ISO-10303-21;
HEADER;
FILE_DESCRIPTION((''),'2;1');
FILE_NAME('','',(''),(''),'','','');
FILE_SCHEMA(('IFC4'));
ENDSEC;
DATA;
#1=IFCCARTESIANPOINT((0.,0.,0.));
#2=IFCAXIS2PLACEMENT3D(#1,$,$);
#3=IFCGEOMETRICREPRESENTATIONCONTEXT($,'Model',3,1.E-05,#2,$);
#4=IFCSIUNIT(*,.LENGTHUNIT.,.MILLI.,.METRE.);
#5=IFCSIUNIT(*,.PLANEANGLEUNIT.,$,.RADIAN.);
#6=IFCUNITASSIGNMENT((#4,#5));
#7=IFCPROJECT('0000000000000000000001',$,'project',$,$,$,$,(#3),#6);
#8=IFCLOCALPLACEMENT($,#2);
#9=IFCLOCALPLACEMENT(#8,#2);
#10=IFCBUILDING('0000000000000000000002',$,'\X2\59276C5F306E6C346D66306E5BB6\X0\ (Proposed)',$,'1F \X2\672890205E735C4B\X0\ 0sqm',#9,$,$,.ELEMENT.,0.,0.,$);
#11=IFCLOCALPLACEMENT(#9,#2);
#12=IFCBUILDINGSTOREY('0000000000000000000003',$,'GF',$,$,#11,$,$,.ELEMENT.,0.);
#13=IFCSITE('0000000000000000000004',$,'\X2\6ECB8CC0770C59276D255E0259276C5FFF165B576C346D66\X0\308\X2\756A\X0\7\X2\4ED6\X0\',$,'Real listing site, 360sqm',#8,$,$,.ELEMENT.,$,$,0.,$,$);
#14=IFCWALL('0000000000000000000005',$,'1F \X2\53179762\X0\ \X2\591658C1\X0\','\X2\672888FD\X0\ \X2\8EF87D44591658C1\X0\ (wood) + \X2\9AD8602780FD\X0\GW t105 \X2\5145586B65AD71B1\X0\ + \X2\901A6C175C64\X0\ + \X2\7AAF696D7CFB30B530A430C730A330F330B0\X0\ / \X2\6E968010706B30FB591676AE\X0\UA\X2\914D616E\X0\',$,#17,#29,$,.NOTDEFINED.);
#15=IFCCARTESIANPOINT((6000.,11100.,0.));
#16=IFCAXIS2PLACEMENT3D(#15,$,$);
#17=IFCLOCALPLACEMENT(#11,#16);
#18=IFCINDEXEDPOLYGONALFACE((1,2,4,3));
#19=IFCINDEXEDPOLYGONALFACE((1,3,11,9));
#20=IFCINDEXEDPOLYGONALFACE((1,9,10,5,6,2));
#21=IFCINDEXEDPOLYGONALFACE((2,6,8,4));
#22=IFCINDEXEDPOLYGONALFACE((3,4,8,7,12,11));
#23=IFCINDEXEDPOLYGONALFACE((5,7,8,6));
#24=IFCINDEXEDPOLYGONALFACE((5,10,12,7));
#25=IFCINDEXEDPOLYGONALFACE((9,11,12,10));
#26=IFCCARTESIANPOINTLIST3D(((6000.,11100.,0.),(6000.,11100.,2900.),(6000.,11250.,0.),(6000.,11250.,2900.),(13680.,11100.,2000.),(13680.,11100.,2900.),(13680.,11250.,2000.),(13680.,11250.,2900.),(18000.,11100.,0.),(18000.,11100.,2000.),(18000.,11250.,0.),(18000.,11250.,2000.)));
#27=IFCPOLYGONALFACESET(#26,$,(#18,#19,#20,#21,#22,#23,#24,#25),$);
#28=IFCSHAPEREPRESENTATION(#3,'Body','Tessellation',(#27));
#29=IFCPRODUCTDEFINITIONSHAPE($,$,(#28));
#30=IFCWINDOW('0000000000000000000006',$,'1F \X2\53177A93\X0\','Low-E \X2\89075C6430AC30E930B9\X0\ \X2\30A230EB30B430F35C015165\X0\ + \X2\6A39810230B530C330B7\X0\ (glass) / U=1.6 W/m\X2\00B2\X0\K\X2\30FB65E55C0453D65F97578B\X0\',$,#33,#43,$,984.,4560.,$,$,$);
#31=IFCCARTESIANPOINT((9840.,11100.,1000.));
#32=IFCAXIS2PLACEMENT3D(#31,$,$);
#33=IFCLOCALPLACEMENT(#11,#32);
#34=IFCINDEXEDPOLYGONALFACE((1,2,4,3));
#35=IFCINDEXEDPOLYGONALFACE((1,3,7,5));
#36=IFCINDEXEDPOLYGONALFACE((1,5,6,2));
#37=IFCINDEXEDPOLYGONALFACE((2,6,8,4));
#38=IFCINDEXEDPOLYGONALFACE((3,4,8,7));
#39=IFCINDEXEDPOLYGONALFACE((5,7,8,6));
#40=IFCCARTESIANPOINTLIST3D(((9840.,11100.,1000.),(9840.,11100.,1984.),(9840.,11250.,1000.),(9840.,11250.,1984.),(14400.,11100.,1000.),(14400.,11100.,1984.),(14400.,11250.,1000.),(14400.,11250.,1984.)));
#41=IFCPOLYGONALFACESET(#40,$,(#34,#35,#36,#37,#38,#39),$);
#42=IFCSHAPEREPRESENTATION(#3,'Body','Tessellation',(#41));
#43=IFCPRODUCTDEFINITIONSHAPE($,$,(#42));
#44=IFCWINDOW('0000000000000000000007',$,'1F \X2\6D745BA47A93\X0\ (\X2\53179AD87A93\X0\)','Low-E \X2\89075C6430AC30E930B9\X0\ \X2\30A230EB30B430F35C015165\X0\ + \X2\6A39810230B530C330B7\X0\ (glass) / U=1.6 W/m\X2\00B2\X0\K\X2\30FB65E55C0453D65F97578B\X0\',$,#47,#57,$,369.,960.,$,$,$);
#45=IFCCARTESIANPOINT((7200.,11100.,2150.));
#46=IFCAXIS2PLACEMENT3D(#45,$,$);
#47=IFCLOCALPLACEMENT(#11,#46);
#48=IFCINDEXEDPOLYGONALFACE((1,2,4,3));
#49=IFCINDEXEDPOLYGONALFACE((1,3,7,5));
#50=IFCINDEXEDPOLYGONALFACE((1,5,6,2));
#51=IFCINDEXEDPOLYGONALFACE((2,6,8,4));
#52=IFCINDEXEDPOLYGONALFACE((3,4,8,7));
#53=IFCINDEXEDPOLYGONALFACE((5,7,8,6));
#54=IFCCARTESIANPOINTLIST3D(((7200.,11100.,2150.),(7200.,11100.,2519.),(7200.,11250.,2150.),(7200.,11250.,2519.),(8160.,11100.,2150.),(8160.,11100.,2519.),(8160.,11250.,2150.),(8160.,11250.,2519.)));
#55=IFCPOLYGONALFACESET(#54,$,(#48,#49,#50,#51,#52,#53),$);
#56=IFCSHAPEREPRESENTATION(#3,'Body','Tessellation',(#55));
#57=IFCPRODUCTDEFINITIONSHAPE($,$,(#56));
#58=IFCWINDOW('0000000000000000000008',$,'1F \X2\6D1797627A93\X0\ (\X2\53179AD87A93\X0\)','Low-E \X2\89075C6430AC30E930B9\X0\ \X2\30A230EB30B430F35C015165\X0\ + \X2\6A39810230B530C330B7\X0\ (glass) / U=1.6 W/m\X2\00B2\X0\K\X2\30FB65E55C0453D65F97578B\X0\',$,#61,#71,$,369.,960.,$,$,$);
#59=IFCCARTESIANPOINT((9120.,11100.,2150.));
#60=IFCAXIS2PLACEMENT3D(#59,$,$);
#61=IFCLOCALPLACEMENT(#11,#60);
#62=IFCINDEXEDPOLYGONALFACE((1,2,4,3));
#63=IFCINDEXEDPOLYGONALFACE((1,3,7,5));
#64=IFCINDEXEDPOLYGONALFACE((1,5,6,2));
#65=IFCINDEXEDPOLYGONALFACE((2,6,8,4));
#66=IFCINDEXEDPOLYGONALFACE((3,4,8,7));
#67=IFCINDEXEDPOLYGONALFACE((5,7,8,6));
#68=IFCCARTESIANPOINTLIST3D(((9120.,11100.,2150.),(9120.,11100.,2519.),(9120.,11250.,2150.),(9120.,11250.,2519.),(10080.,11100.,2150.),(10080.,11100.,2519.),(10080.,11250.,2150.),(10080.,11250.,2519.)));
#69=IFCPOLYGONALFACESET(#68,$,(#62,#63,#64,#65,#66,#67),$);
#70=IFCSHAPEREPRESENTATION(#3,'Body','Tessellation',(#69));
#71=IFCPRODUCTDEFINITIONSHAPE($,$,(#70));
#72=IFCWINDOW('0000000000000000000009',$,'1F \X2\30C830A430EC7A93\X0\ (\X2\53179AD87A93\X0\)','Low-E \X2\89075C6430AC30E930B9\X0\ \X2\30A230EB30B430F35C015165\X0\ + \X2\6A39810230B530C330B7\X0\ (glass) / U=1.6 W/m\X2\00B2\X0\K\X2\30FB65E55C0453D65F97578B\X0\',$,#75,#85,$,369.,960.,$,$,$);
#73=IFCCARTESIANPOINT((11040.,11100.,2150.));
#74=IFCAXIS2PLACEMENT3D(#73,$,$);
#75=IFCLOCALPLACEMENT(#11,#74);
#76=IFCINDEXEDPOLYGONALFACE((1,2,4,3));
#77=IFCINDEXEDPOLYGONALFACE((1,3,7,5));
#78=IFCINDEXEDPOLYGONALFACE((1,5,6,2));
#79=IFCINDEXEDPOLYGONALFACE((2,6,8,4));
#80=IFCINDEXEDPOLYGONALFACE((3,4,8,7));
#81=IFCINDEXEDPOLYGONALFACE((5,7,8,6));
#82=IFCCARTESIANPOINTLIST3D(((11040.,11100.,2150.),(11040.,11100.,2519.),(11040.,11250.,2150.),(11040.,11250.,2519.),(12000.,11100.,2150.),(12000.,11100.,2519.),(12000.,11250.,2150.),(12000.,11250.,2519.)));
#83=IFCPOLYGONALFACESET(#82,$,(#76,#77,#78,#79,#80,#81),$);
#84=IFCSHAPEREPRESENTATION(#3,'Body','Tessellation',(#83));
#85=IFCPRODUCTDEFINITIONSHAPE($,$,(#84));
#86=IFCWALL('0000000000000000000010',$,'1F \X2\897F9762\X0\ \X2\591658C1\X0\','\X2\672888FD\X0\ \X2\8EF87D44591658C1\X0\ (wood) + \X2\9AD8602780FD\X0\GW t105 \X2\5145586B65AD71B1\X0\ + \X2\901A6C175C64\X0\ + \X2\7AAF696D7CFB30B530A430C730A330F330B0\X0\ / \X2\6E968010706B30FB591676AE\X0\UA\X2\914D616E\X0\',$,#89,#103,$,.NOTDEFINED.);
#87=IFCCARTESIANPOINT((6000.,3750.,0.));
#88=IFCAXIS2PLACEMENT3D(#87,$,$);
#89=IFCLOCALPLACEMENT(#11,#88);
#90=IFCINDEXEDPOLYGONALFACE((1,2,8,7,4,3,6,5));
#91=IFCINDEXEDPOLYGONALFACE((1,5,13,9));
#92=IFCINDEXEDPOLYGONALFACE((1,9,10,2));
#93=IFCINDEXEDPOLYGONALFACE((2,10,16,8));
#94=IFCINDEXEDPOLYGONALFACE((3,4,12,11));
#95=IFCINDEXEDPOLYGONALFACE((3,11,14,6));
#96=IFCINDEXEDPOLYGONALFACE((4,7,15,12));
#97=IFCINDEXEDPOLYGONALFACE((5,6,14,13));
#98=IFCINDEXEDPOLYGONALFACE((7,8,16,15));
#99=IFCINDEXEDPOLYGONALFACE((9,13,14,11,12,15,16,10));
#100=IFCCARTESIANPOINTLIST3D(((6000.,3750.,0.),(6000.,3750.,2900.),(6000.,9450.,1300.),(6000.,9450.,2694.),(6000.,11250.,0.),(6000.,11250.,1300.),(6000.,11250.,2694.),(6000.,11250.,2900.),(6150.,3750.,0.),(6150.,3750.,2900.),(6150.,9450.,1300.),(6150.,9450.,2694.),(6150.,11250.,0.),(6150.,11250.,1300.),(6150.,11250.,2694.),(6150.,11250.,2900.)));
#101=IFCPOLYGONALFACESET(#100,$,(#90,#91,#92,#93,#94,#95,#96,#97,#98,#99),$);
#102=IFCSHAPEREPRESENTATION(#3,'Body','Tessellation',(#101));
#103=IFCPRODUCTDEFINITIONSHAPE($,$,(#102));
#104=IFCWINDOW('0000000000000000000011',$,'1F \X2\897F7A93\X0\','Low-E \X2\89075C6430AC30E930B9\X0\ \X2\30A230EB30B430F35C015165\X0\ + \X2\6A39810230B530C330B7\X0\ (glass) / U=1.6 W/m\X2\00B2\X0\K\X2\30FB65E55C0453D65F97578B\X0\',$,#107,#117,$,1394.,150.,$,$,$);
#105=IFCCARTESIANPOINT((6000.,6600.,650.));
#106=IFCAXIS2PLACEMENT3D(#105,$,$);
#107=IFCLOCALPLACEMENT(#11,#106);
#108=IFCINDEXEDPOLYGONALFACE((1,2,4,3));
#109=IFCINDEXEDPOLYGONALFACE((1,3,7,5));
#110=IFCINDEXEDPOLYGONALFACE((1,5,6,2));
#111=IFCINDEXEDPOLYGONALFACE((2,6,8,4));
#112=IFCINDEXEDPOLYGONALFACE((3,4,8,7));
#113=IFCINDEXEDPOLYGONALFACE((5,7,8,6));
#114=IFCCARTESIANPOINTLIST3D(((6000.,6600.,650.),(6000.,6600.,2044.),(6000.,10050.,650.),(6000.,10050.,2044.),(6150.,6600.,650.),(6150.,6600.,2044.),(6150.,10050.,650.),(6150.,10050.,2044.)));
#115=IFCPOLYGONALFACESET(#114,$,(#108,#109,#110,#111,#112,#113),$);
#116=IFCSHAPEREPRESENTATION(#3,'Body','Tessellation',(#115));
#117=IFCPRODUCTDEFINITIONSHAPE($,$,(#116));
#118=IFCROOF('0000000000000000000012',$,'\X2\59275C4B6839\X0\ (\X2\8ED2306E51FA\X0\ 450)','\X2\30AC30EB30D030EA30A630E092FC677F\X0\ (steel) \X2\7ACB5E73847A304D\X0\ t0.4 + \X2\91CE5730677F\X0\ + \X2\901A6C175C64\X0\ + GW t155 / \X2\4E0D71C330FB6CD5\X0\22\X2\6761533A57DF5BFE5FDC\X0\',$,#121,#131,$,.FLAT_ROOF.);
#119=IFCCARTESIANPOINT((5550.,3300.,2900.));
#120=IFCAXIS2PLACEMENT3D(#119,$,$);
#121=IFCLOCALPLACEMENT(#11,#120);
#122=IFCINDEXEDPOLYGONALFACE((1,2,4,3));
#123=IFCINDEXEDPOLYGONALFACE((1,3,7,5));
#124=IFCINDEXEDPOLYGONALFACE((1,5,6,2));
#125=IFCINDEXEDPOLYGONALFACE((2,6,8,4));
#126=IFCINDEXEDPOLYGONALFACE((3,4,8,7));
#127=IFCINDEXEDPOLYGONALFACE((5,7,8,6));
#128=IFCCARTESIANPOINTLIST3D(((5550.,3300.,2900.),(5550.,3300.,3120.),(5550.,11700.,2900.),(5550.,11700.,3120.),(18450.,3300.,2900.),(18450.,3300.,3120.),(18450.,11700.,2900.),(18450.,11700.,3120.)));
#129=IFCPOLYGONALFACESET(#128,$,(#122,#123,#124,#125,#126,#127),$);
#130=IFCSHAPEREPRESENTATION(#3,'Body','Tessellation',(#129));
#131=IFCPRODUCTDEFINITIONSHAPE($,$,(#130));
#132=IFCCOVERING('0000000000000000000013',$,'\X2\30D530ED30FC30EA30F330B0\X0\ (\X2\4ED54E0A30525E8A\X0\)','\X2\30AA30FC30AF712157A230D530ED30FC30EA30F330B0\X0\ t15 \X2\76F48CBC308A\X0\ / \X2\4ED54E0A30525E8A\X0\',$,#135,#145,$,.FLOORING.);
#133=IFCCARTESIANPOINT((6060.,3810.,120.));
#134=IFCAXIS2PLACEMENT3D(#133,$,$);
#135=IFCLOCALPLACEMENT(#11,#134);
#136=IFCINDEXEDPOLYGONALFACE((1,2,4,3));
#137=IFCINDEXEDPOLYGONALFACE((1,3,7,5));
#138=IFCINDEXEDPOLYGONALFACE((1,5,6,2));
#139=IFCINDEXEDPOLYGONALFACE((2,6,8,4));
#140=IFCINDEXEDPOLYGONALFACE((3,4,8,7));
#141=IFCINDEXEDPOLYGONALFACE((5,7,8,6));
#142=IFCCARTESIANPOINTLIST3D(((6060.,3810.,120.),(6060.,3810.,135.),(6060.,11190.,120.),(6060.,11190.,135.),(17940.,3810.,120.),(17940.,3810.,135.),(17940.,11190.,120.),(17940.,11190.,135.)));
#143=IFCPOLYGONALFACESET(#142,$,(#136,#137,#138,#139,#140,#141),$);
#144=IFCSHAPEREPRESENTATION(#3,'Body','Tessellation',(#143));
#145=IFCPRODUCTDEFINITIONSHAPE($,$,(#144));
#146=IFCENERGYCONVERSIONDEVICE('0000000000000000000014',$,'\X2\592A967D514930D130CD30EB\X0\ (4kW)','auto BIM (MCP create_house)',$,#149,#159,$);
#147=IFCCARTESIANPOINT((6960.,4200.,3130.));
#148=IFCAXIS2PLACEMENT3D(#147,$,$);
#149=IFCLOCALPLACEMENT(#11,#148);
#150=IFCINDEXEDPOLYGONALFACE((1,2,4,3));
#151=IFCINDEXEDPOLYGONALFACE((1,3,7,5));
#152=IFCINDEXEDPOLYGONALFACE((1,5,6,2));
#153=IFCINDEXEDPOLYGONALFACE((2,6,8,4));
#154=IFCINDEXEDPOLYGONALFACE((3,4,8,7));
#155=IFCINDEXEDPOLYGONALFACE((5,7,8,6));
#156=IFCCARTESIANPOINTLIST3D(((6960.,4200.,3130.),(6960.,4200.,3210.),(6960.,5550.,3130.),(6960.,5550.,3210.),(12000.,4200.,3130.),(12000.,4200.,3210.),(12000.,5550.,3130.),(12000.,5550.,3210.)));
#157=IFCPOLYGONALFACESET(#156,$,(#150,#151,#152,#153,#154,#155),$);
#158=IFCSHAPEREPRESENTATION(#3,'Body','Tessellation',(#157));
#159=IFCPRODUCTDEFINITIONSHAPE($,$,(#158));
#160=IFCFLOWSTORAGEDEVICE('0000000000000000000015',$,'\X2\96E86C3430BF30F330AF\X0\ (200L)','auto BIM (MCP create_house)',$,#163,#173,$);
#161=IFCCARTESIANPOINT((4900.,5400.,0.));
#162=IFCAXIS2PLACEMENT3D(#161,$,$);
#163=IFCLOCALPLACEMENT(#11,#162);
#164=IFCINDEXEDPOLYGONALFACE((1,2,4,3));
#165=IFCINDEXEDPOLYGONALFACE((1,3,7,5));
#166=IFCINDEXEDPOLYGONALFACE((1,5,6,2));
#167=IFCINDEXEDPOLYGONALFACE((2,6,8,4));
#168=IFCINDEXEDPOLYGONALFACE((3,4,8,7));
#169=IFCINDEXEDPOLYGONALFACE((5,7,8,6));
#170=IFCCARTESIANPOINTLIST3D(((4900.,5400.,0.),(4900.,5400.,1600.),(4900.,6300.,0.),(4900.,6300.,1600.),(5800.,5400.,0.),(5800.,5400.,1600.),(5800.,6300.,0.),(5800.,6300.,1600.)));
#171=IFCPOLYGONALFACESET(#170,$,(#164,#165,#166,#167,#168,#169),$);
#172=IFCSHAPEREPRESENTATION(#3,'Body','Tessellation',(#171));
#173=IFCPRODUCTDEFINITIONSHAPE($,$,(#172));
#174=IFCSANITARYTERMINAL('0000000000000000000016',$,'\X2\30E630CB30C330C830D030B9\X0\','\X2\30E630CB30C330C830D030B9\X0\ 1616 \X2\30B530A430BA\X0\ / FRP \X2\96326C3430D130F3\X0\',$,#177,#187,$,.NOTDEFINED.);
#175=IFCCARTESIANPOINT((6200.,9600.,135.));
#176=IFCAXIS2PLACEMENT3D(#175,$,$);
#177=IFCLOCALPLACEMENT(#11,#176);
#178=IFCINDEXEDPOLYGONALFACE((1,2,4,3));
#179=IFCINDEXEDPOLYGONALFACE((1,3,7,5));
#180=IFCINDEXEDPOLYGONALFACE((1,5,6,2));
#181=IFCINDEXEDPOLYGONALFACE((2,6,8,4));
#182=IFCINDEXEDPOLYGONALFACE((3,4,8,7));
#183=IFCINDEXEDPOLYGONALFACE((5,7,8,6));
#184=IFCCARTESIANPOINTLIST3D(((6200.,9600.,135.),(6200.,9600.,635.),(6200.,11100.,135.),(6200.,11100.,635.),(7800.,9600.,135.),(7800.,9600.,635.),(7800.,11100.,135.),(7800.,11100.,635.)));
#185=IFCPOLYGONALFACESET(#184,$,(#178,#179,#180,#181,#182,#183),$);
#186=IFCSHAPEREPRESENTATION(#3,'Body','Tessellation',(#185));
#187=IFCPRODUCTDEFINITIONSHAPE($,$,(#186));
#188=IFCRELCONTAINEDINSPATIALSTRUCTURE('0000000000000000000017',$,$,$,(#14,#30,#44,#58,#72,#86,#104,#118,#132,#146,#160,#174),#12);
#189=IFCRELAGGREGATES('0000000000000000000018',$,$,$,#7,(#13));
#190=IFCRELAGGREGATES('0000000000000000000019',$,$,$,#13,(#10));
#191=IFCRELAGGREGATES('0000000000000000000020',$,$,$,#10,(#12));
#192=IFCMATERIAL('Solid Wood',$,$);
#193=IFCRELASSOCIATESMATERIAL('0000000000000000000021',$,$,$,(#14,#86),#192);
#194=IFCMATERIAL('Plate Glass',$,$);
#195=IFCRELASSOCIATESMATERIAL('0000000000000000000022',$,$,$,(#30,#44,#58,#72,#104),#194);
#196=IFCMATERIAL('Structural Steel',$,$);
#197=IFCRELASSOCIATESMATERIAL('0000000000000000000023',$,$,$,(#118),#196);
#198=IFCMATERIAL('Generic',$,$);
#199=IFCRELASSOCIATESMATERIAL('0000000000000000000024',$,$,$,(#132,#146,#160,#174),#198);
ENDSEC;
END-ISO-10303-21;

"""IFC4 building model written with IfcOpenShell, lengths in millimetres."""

from ifc_helpers import new_model, si_unit, frame, frame_2d, origin, place, context, project, spatial, rectangle, extrude, material, element, fill, save


model = new_model("IFC4")

# Units and contexts
model_context = context("Model", 3, precision=1e-05, world=origin())
ifc_project = project(units=[si_unit("LENGTHUNIT", "METRE", prefix="MILLI"), si_unit("PLANEANGLEUNIT", "RADIAN")], contexts=[model_context])

# Site, building, storey
site_placement = place(None, origin())
site = spatial("IfcSite", under=ifc_project, at=site_placement, Name="滋賀県大津市大江６字水浦308番7他", ObjectType="Real listing site, 360sqm", CompositionType="ELEMENT", RefElevation=0.0)
building_placement = place(site_placement, origin())
building = spatial("IfcBuilding", under=site, at=building_placement, Name="大江の水浦の家 (Proposed)", ObjectType="1F 木造平屋 0sqm", CompositionType="ELEMENT", ElevationOfRefHeight=0.0, ElevationOfTerrain=0.0)
storey_placement = place(building_placement, origin())
storey = spatial("IfcBuildingStorey", under=building, at=storey_placement, Name="GF", CompositionType="ELEMENT", Elevation=0.0)

# Shared definitions
ifc_material_1 = material(Name="Solid Wood")

# Shared definitions
ifc_material_2 = material(Name="Plate Glass")

# Wall, openings, windows
wall_1_placement = place(storey_placement, frame((6000.0, 11100.0, 0.0)))
wall_1 = element("IfcWall", 1, at=wall_1_placement, inside=storey, material=ifc_material_1, Name="1F 北面 外壁", Description="木製 軸組外壁 (wood) + 高性能GW t105 充填断熱 + 通気層 + 窯業系サイディング / 準耐火・外皮UA配慮", PredefinedType="NOTDEFINED", context=model_context, shape_type="SweptSolid", body=[
    extrude(rectangle(XDim=12000.0, YDim=150.0, at=frame_2d((6000.0, 75.0))), frame((6000.0, 11100.0, 0.0)), (0.0, 0.0, 1.0), 2900.0),
])
opening_1_placement = place(storey_placement, frame((9840.0, 11100.0, 1000.0)))
opening_1 = element("IfcOpeningElement", 2, at=opening_1_placement, cuts=wall_1, PredefinedType="NOTDEFINED", context=model_context, shape_type="SweptSolid", body=[
    extrude(rectangle(XDim=4560.0, YDim=150.0, at=frame_2d((2280.0, 75.0))), frame((9840.0, 11100.0, 1000.0)), (0.0, 0.0, 1.0), 984.0),
])
opening_2_placement = place(storey_placement, frame((7200.0, 11100.0, 2150.0)))
opening_2 = element("IfcOpeningElement", 3, at=opening_2_placement, cuts=wall_1, PredefinedType="NOTDEFINED", context=model_context, shape_type="SweptSolid", body=[
    extrude(rectangle(XDim=960.0, YDim=150.0, at=frame_2d((480.0, 75.0))), frame((7200.0, 11100.0, 2150.0)), (0.0, 0.0, 1.0), 369.0),
])
opening_3_placement = place(storey_placement, frame((9120.0, 11100.0, 2150.0)))
opening_3 = element("IfcOpeningElement", 4, at=opening_3_placement, cuts=wall_1, PredefinedType="NOTDEFINED", context=model_context, shape_type="SweptSolid", body=[
    extrude(rectangle(XDim=960.0, YDim=150.0, at=frame_2d((480.0, 75.0))), frame((9120.0, 11100.0, 2150.0)), (0.0, 0.0, 1.0), 369.0),
])
opening_4_placement = place(storey_placement, frame((11040.0, 11100.0, 2150.0)))
opening_4 = element("IfcOpeningElement", 5, at=opening_4_placement, cuts=wall_1, PredefinedType="NOTDEFINED", context=model_context, shape_type="SweptSolid", body=[
    extrude(rectangle(XDim=960.0, YDim=150.0, at=frame_2d((480.0, 75.0))), frame((11040.0, 11100.0, 2150.0)), (0.0, 0.0, 1.0), 369.0),
])
window_1_placement = place(storey_placement, frame((9840.0, 11100.0, 1000.0)))
window_1 = element("IfcWindow", 6, at=window_1_placement, inside=storey, material=ifc_material_2, Name="1F 北窓", Description="Low-E 複層ガラス アルゴン封入 + 樹脂サッシ (glass) / U=1.6 W/m²K・日射取得型", OverallHeight=984.0, OverallWidth=4560.0, context=model_context, shape_type="SweptSolid", body=[
    extrude(rectangle(XDim=4560.0, YDim=150.0, at=frame_2d((2280.0, 75.0))), frame((9840.0, 11100.0, 1000.0)), (0.0, 0.0, 1.0), 984.0),
])
fill(opening_1, window_1)
window_2_placement = place(storey_placement, frame((7200.0, 11100.0, 2150.0)))
window_2 = element("IfcWindow", 7, at=window_2_placement, inside=storey, material=ifc_material_2, Name="1F 浴室窓 (北高窓)", Description="Low-E 複層ガラス アルゴン封入 + 樹脂サッシ (glass) / U=1.6 W/m²K・日射取得型", OverallHeight=369.0, OverallWidth=960.0, context=model_context, shape_type="SweptSolid", body=[
    extrude(rectangle(XDim=960.0, YDim=150.0, at=frame_2d((480.0, 75.0))), frame((7200.0, 11100.0, 2150.0)), (0.0, 0.0, 1.0), 369.0),
])
fill(opening_2, window_2)
window_3_placement = place(storey_placement, frame((9120.0, 11100.0, 2150.0)))
window_3 = element("IfcWindow", 8, at=window_3_placement, inside=storey, material=ifc_material_2, Name="1F 洗面窓 (北高窓)", Description="Low-E 複層ガラス アルゴン封入 + 樹脂サッシ (glass) / U=1.6 W/m²K・日射取得型", OverallHeight=369.0, OverallWidth=960.0, context=model_context, shape_type="SweptSolid", body=[
    extrude(rectangle(XDim=960.0, YDim=150.0, at=frame_2d((480.0, 75.0))), frame((9120.0, 11100.0, 2150.0)), (0.0, 0.0, 1.0), 369.0),
])
fill(opening_3, window_3)
window_4_placement = place(storey_placement, frame((11040.0, 11100.0, 2150.0)))
window_4 = element("IfcWindow", 9, at=window_4_placement, inside=storey, material=ifc_material_2, Name="1F トイレ窓 (北高窓)", Description="Low-E 複層ガラス アルゴン封入 + 樹脂サッシ (glass) / U=1.6 W/m²K・日射取得型", OverallHeight=369.0, OverallWidth=960.0, context=model_context, shape_type="SweptSolid", body=[
    extrude(rectangle(XDim=960.0, YDim=150.0, at=frame_2d((480.0, 75.0))), frame((11040.0, 11100.0, 2150.0)), (0.0, 0.0, 1.0), 369.0),
])
fill(opening_4, window_4)

# Wall, opening, window
wall_2_placement = place(storey_placement, frame((6000.0, 3750.0, 0.0)))
wall_2 = element("IfcWall", 10, at=wall_2_placement, inside=storey, material=ifc_material_1, Name="1F 西面 外壁", Description="木製 軸組外壁 (wood) + 高性能GW t105 充填断熱 + 通気層 + 窯業系サイディング / 準耐火・外皮UA配慮", PredefinedType="NOTDEFINED", context=model_context, shape_type="SweptSolid", body=[
    extrude(rectangle(XDim=150.0, YDim=7500.0, at=frame_2d((75.0, 3750.0))), frame((6000.0, 3750.0, 0.0)), (0.0, 0.0, 1.0), 2900.0),
])
opening_5_placement = place(storey_placement, frame((6000.0, 6600.0, 650.0)))
opening_5 = element("IfcOpeningElement", 11, at=opening_5_placement, cuts=wall_2, PredefinedType="NOTDEFINED", context=model_context, shape_type="SweptSolid", body=[
    extrude(rectangle(XDim=150.0, YDim=3450.0, at=frame_2d((75.0, 1725.0))), frame((6000.0, 6600.0, 650.0)), (0.0, 0.0, 1.0), 1394.0),
])
window_5_placement = place(storey_placement, frame((6000.0, 6600.0, 650.0)))
window_5 = element("IfcWindow", 12, at=window_5_placement, inside=storey, material=ifc_material_2, Name="1F 西窓", Description="Low-E 複層ガラス アルゴン封入 + 樹脂サッシ (glass) / U=1.6 W/m²K・日射取得型", OverallHeight=1394.0, OverallWidth=150.0, context=model_context, shape_type="SweptSolid", body=[
    extrude(rectangle(XDim=150.0, YDim=3450.0, at=frame_2d((75.0, 1725.0))), frame((6000.0, 6600.0, 650.0)), (0.0, 0.0, 1.0), 1394.0),
])
fill(opening_5, window_5)

# Roof
ifc_material_3 = material(Name="Structural Steel")
roof_placement = place(storey_placement, frame((5550.0, 3300.0, 2900.0)))
element("IfcRoof", 13, at=roof_placement, inside=storey, material=ifc_material_3, Name="大屋根 (軒の出 450)", Description="ガルバリウム鋼板 (steel) 立平葺き t0.4 + 野地板 + 通気層 + GW t155 / 不燃・法22条区域対応", PredefinedType="FLAT_ROOF", context=model_context, shape_type="SweptSolid", body=[
    extrude(rectangle(XDim=12900.0, YDim=8400.0, at=frame_2d((6450.0, 4200.0))), frame((5550.0, 3300.0, 2900.0)), (0.0, 0.0, 1.0), 220.0),
])

# Covering
ifc_material_4 = material(Name="Generic")
covering_placement = place(storey_placement, frame((6060.0, 3810.0, 120.0)))
element("IfcCovering", 14, at=covering_placement, inside=storey, material=ifc_material_4, Name="フローリング (仕上げ床)", Description="オーク無垢フローリング t15 直貼り / 仕上げ床", PredefinedType="FLOORING", context=model_context, shape_type="SweptSolid", body=[
    extrude(rectangle(XDim=11880.0, YDim=7380.0, at=frame_2d((5940.0, 3690.0))), frame((6060.0, 3810.0, 120.0)), (0.0, 0.0, 1.0), 15.0),
])

# Energy conversion device
energy_conversion_device_placement = place(storey_placement, frame((6960.0, 4200.0, 3130.0)))
element("IfcEnergyConversionDevice", 15, at=energy_conversion_device_placement, inside=storey, material=ifc_material_4, Name="太陽光パネル (4kW)", Description="auto BIM (MCP create_house)", context=model_context, shape_type="SweptSolid", body=[
    extrude(rectangle(XDim=5040.0, YDim=1350.0, at=frame_2d((2520.0, 675.0))), frame((6960.0, 4200.0, 3130.0)), (0.0, 0.0, 1.0), 80.0),
])

# Flow storage device
flow_storage_device_placement = place(storey_placement, frame((4900.0, 5400.0, 0.0)))
element("IfcFlowStorageDevice", 16, at=flow_storage_device_placement, inside=storey, material=ifc_material_4, Name="雨水タンク (200L)", Description="auto BIM (MCP create_house)", context=model_context, shape_type="SweptSolid", body=[
    extrude(rectangle(XDim=900.0, YDim=900.0, at=frame_2d((450.0, 450.0))), frame((4900.0, 5400.0, 0.0)), (0.0, 0.0, 1.0), 1600.0),
])

# Sanitary terminal
sanitary_terminal_placement = place(storey_placement, frame((6200.0, 9600.0, 135.0)))
element("IfcSanitaryTerminal", 17, at=sanitary_terminal_placement, inside=storey, material=ifc_material_4, Name="ユニットバス", Description="ユニットバス 1616 サイズ / FRP 防水パン", PredefinedType="NOTDEFINED", context=model_context, shape_type="SweptSolid", body=[
    extrude(rectangle(XDim=1600.0, YDim=1500.0, at=frame_2d((800.0, 750.0))), frame((6200.0, 9600.0, 135.0)), (0.0, 0.0, 1.0), 500.0),
])

save(model, "model.ifc")
